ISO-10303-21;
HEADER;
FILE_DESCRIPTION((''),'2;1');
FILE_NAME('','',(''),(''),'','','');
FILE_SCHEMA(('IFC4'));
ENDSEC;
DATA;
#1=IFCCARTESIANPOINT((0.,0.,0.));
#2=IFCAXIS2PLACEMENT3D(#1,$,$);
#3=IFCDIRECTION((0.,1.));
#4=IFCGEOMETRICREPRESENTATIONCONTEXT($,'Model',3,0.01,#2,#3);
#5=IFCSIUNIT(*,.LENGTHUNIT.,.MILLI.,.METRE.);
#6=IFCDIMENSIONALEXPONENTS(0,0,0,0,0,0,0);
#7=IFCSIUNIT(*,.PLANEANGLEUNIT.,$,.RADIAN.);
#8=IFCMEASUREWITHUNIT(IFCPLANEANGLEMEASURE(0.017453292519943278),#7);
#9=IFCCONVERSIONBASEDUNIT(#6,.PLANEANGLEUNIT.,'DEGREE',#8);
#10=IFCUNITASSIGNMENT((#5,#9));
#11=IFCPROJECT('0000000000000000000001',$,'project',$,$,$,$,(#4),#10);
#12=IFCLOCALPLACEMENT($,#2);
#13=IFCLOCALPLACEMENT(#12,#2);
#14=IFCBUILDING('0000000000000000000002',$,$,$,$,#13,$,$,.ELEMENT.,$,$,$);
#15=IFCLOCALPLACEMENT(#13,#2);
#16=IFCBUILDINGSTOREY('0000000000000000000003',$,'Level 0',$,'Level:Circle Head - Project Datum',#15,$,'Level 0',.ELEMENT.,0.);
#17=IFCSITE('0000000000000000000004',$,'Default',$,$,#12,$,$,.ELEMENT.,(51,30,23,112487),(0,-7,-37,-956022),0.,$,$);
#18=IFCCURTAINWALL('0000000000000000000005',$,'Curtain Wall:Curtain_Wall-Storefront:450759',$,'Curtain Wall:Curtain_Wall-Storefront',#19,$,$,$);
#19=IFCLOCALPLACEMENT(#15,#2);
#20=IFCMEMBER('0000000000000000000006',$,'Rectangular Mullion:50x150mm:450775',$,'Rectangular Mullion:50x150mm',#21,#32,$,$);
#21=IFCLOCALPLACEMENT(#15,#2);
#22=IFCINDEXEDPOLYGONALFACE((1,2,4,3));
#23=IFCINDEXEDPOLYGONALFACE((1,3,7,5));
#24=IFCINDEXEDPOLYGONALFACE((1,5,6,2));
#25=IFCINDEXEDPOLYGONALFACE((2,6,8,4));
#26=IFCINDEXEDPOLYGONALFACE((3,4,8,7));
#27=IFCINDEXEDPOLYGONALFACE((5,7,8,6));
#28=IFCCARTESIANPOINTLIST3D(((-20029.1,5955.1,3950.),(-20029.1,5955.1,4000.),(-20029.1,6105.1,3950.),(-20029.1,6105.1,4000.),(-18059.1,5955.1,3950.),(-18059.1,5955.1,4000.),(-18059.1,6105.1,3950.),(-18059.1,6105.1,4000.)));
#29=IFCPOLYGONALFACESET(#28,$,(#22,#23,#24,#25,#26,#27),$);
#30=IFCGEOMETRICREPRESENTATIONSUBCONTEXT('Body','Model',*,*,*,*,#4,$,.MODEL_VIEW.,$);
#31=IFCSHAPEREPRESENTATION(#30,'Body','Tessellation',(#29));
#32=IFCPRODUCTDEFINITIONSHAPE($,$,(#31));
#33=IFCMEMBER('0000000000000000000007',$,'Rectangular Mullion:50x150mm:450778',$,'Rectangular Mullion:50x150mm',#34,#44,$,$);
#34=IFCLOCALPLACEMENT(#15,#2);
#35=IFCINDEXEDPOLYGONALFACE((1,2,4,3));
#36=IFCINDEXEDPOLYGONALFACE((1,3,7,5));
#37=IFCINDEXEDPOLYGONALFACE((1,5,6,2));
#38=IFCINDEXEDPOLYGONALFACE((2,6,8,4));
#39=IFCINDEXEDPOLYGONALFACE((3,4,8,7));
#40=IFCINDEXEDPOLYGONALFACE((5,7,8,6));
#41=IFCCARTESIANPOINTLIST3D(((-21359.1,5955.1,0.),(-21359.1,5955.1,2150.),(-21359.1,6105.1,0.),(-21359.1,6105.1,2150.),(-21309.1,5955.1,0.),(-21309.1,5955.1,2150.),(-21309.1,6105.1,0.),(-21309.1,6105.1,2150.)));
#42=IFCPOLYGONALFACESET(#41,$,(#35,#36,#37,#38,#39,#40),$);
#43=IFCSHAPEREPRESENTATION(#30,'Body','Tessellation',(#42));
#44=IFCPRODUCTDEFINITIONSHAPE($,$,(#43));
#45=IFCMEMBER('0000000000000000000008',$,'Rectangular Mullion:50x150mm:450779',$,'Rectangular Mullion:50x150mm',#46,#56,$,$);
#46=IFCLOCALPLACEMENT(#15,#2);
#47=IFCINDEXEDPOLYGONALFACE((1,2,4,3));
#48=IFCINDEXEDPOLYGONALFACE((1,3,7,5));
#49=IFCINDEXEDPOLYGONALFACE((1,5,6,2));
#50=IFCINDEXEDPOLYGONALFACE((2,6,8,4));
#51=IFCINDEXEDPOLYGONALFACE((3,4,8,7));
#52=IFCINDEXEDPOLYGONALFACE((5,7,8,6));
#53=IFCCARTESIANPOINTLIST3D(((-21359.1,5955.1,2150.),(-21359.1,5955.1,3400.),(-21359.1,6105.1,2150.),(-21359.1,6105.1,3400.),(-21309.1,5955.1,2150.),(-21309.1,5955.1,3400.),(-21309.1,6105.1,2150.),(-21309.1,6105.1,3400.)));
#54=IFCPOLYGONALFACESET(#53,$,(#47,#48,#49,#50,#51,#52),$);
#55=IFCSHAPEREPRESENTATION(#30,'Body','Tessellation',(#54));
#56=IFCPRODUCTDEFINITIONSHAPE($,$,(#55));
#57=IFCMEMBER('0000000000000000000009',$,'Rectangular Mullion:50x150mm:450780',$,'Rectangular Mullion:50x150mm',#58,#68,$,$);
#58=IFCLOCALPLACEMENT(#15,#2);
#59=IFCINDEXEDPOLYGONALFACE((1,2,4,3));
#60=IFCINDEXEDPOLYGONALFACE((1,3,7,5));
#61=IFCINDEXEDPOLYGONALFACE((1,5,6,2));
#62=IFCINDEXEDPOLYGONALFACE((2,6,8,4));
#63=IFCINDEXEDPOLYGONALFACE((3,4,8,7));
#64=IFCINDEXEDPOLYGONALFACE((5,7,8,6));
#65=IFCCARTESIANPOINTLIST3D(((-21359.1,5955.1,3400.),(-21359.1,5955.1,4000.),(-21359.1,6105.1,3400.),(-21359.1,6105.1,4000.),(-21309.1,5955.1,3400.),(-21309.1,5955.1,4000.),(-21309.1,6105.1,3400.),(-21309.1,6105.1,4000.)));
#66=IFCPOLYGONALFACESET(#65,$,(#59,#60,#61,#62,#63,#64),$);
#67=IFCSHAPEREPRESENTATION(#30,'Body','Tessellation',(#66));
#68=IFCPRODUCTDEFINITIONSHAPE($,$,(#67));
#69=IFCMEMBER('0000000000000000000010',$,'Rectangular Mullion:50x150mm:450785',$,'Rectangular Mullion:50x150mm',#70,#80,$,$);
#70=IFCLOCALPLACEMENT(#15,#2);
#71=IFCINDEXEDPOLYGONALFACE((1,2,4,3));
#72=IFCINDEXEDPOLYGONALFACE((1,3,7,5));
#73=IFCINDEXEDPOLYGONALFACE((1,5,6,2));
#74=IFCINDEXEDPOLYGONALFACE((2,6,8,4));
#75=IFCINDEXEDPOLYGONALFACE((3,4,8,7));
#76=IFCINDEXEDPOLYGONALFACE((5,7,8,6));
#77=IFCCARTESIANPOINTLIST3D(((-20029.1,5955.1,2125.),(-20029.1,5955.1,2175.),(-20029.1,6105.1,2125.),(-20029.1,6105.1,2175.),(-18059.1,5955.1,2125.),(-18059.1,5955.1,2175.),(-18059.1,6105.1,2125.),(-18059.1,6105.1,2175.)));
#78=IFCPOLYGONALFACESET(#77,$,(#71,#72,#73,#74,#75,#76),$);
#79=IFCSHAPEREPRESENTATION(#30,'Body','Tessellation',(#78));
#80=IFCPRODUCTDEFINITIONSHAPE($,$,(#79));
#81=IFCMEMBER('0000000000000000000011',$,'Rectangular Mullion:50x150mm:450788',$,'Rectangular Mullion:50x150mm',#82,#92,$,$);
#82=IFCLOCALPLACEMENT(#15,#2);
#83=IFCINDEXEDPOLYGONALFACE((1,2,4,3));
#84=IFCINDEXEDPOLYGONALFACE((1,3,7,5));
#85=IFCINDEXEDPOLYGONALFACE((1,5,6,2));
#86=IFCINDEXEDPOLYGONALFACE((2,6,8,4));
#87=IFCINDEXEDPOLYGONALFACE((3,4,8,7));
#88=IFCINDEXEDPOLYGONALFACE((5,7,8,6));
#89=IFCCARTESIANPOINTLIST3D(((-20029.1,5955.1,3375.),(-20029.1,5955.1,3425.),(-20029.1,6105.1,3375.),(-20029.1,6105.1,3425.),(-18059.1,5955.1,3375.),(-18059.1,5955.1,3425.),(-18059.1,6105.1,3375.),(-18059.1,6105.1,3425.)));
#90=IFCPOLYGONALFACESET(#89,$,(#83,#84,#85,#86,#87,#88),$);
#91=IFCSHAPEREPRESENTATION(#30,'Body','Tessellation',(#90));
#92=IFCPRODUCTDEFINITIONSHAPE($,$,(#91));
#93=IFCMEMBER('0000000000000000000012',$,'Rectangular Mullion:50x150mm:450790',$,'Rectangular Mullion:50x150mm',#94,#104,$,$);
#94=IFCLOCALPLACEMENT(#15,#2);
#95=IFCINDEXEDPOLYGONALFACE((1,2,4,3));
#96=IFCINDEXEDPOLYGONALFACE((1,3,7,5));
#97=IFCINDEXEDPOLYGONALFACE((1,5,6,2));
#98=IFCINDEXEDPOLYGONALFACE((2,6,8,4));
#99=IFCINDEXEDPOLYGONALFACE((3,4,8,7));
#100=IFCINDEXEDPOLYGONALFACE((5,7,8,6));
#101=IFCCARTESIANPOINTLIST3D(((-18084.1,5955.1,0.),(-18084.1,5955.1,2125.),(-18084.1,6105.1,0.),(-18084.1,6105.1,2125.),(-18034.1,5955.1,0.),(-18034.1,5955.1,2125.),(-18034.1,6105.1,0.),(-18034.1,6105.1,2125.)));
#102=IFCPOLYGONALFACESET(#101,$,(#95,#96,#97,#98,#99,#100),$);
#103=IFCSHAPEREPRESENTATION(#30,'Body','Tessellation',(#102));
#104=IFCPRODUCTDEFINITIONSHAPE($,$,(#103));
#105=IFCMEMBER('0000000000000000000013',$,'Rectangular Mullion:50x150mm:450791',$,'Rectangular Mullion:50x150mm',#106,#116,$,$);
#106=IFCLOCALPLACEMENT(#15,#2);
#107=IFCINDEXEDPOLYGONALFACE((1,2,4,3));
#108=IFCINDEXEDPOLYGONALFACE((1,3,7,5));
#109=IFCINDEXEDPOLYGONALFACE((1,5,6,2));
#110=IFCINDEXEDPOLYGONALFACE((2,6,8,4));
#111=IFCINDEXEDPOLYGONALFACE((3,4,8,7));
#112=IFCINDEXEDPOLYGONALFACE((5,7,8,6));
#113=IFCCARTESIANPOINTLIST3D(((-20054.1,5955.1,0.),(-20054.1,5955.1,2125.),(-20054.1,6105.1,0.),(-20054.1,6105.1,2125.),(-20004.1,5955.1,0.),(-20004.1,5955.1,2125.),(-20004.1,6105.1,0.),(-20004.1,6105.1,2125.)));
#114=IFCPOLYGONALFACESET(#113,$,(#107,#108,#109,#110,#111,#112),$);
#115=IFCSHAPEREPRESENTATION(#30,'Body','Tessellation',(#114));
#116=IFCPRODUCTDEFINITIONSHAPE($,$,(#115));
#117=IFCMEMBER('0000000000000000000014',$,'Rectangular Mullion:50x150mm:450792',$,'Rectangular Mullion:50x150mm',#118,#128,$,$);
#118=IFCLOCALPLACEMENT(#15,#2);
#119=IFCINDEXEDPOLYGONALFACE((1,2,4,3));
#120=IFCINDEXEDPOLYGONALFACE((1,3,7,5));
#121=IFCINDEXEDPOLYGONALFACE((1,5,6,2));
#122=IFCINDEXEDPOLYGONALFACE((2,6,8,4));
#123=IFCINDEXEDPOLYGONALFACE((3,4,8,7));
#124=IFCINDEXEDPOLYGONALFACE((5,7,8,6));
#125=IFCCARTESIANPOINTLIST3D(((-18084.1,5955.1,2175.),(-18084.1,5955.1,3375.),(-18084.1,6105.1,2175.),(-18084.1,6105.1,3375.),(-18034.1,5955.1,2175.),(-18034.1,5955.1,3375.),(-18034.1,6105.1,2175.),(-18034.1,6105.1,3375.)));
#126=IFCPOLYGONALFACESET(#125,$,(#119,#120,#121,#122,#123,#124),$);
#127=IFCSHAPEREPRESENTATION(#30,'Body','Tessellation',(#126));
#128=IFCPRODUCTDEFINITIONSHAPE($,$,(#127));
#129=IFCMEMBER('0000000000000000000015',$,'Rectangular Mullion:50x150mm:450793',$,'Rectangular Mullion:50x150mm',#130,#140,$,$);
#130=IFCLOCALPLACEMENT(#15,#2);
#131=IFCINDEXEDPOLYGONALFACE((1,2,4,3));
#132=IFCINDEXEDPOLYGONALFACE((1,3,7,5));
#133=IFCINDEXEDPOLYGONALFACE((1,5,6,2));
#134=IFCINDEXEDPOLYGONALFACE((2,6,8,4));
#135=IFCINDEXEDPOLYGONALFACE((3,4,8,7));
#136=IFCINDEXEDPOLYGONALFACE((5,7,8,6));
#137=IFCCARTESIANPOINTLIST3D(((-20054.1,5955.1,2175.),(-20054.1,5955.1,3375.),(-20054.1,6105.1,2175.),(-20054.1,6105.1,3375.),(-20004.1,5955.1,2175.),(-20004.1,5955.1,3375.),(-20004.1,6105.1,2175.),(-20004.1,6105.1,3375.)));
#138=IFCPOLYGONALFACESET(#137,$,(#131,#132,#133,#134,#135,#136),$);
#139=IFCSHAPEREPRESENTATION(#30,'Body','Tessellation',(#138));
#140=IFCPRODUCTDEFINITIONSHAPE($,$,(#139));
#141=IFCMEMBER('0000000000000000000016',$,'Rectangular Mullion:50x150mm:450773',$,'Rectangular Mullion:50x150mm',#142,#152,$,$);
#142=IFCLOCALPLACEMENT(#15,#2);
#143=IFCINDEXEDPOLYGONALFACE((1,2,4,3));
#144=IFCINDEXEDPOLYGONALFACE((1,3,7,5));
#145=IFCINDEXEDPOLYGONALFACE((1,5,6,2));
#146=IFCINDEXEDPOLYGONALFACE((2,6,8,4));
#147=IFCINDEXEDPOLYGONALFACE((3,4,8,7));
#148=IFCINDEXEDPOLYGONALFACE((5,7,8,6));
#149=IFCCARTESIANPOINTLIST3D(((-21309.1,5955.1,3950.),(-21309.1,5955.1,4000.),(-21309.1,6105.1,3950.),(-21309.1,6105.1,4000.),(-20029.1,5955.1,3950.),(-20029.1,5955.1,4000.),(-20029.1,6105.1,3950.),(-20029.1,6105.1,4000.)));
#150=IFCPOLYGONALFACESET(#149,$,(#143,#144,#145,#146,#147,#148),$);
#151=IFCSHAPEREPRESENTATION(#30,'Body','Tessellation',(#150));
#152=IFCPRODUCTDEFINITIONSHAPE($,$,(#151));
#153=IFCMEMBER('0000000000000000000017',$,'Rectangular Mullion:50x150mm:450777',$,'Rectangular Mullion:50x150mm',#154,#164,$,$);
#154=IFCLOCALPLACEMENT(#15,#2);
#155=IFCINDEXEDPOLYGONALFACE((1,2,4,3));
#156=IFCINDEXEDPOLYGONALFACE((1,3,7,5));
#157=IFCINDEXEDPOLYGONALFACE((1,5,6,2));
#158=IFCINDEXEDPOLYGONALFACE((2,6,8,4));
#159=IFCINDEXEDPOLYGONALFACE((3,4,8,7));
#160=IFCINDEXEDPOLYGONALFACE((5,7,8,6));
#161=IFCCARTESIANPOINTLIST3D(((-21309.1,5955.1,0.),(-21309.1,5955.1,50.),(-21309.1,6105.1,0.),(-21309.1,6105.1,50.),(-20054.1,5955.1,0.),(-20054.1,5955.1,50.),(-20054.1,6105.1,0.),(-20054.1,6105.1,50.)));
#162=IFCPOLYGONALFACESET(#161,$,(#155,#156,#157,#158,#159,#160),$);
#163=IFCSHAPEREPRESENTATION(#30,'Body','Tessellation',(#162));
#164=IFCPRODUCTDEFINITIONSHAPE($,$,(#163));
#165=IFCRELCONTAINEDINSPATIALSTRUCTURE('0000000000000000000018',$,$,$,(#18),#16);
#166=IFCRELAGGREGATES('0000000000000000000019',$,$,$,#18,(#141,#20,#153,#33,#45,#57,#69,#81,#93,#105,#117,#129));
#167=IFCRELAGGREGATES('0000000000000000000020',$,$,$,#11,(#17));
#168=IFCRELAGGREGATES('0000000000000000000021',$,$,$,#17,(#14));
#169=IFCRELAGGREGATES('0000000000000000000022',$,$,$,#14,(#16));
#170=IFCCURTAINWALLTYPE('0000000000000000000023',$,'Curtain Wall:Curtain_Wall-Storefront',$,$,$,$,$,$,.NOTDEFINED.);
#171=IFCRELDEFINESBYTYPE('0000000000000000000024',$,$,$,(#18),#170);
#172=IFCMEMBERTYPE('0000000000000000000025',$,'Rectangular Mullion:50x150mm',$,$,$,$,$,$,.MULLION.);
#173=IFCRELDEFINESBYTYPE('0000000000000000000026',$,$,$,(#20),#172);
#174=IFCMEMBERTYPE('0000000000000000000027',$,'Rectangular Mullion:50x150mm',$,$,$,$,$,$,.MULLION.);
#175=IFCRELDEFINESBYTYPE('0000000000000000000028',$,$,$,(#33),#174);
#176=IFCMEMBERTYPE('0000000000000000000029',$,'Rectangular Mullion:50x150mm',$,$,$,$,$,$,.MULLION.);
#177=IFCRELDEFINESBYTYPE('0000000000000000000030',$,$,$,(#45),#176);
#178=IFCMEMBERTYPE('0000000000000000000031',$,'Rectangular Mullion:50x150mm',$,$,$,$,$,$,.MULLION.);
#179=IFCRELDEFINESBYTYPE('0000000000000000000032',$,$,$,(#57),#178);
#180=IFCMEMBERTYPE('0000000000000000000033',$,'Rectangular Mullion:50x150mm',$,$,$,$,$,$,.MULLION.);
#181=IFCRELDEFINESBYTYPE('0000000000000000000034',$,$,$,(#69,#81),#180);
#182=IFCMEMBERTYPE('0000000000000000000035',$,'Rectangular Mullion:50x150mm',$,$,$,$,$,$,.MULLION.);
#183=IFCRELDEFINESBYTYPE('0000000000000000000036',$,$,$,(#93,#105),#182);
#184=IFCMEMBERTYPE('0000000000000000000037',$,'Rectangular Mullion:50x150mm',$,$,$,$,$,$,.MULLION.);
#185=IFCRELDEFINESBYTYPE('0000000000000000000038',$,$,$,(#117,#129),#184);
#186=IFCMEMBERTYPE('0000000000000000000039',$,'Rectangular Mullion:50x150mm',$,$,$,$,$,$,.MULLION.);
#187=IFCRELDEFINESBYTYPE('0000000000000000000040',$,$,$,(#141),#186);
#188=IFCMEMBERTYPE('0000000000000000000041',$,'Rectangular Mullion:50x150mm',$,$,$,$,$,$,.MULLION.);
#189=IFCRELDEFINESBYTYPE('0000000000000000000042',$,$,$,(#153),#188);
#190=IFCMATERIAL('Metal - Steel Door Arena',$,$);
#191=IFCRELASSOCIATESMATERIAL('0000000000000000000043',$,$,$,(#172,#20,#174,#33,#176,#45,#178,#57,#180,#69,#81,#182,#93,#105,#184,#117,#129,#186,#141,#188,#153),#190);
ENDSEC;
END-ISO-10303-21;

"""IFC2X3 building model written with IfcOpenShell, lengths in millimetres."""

from ifc_helpers import new_model, entity, si_unit, converted_unit, direction, frame, origin, origin_2d_with_axis, place, context, subcontext, project, spatial, rectangle, extrude, source, transform, mapped, material, type_object, type_shapes, element, aggregate, save


model = new_model("IFC2X3")

# Units and contexts
model_context = context("Model", 3, precision=0.01, world=origin(), true_north=direction((0.0, 1.0)))
body_context = subcontext(model_context, "Body", "Model", "MODEL_VIEW")
ifc_project = project(units=[si_unit("LENGTHUNIT", "METRE", prefix="MILLI"), converted_unit("PLANEANGLEUNIT", "DEGREE", entity("IfcPlaneAngleMeasure", 0.017453292519943278), si_unit("PLANEANGLEUNIT", "RADIAN"), dimensions=[0, 0, 0, 0, 0, 0, 0])], contexts=[model_context])

# Site, building, storey
site_placement = place(None, origin())
site = spatial("IfcSite", under=ifc_project, at=site_placement, Name="Default", CompositionType="ELEMENT", RefLatitude=(51, 30, 23, 112487), RefLongitude=(0, -7, -37, -956022), RefElevation=0.0)
building_placement = place(site_placement, origin())
building = spatial("IfcBuilding", under=site, at=building_placement, CompositionType="ELEMENT")
storey_placement = place(building_placement, origin())
storey = spatial("IfcBuildingStorey", under=building, at=storey_placement, Name="Level 0", ObjectType="Level:Circle Head - Project Datum", LongName="Level 0", CompositionType="ELEMENT", Elevation=0.0)

# Curtain wall, members
curtain_wall_type = type_object("IfcCurtainWallType", Name="Curtain Wall:Curtain_Wall-Storefront", PredefinedType="NOTDEFINED")
curtain_wall_placement = place(storey_placement, origin())
curtain_wall = element("IfcCurtainWall", 1, at=curtain_wall_placement, inside=storey, type_object=curtain_wall_type, Name="Curtain Wall:Curtain_Wall-Storefront:450759", ObjectType="Curtain Wall:Curtain_Wall-Storefront")
ifc_material_1 = material(Name="Metal - Steel Door Arena")
member_type_1 = type_object("IfcMemberType", Name="Rectangular Mullion:50x150mm", PredefinedType="MULLION", material=ifc_material_1)
shared_shape_1 = source(origin(), body_context, "Body", "SweptSolid", [
    extrude(rectangle(XDim=50.0, YDim=150.0, at=origin_2d_with_axis()), frame((-25.0, 0.0, -1970.0), z_axis=(0.0, 0.0, 1.0), x_axis=(-1.0, 0.0, 0.0)), (0.0, 0.0, 1.0), 1970.0),
])
type_shapes(member_type_1, [shared_shape_1])
member_1_placement = place(curtain_wall_placement, frame((-20029.1, 6030.1, 4000.0), z_axis=(-1.0, 0.0, 0.0), x_axis=(0.0, 0.0, 1.0)))
member_1 = element("IfcMember", 2, at=member_1_placement, type_object=member_type_1, material=ifc_material_1, Name="Rectangular Mullion:50x150mm:450775", ObjectType="Rectangular Mullion:50x150mm", context=body_context, shape_type="MappedRepresentation", body=[
    mapped(shared_shape_1, transform((0.0, 0.0, 0.0), scale=1.0)),
])
member_type_2 = type_object("IfcMemberType", Name="Rectangular Mullion:50x150mm", PredefinedType="MULLION", material=ifc_material_1)
shared_shape_2 = source(origin(), body_context, "Body", "SweptSolid", [
    extrude(rectangle(XDim=50.0, YDim=150.0, at=origin_2d_with_axis()), frame((-25.0, 0.0, -2150.0), z_axis=(0.0, 0.0, 1.0), x_axis=(-1.0, 0.0, 0.0)), (0.0, 0.0, 1.0), 2150.0),
])
type_shapes(member_type_2, [shared_shape_2])
member_2_placement = place(curtain_wall_placement, frame((-21359.1, 6030.1, 0.0), z_axis=(0.0, 0.0, -1.0), x_axis=(-1.0, 0.0, 0.0)))
member_2 = element("IfcMember", 3, at=member_2_placement, type_object=member_type_2, material=ifc_material_1, Name="Rectangular Mullion:50x150mm:450778", ObjectType="Rectangular Mullion:50x150mm", context=body_context, shape_type="MappedRepresentation", body=[
    mapped(shared_shape_2, transform((0.0, 0.0, 0.0), scale=1.0)),
])
member_type_3 = type_object("IfcMemberType", Name="Rectangular Mullion:50x150mm", PredefinedType="MULLION", material=ifc_material_1)
shared_shape_3 = source(origin(), body_context, "Body", "SweptSolid", [
    extrude(rectangle(XDim=50.0, YDim=150.0, at=origin_2d_with_axis()), frame((-25.0, 0.0, -1250.0), z_axis=(0.0, 0.0, 1.0), x_axis=(-1.0, 0.0, 0.0)), (0.0, 0.0, 1.0), 1250.0),
])
type_shapes(member_type_3, [shared_shape_3])
member_3_placement = place(curtain_wall_placement, frame((-21359.1, 6030.1, 2150.0), z_axis=(0.0, 0.0, -1.0), x_axis=(-1.0, 0.0, 0.0)))
member_3 = element("IfcMember", 4, at=member_3_placement, type_object=member_type_3, material=ifc_material_1, Name="Rectangular Mullion:50x150mm:450779", ObjectType="Rectangular Mullion:50x150mm", context=body_context, shape_type="MappedRepresentation", body=[
    mapped(shared_shape_3, transform((0.0, 0.0, 0.0), scale=1.0)),
])
member_type_4 = type_object("IfcMemberType", Name="Rectangular Mullion:50x150mm", PredefinedType="MULLION", material=ifc_material_1)
shared_shape_4 = source(origin(), body_context, "Body", "SweptSolid", [
    extrude(rectangle(XDim=50.0, YDim=150.0, at=origin_2d_with_axis()), frame((-25.0, 0.0, -600.0), z_axis=(0.0, 0.0, 1.0), x_axis=(-1.0, 0.0, 0.0)), (0.0, 0.0, 1.0), 600.0),
])
type_shapes(member_type_4, [shared_shape_4])
member_4_placement = place(curtain_wall_placement, frame((-21359.1, 6030.1, 3400.0), z_axis=(0.0, 0.0, -1.0), x_axis=(-1.0, 0.0, 0.0)))
member_4 = element("IfcMember", 5, at=member_4_placement, type_object=member_type_4, material=ifc_material_1, Name="Rectangular Mullion:50x150mm:450780", ObjectType="Rectangular Mullion:50x150mm", context=body_context, shape_type="MappedRepresentation", body=[
    mapped(shared_shape_4, transform((0.0, 0.0, 0.0), scale=1.0)),
])
member_type_5 = type_object("IfcMemberType", Name="Rectangular Mullion:50x150mm", PredefinedType="MULLION", material=ifc_material_1)
shared_shape_5 = source(origin(), body_context, "Body", "SweptSolid", [
    extrude(rectangle(XDim=50.0, YDim=150.0, at=origin_2d_with_axis()), frame((0.0, 0.0, -1970.0), z_axis=(0.0, 0.0, 1.0), x_axis=(-1.0, 0.0, 0.0)), (0.0, 0.0, 1.0), 1970.0),
])
type_shapes(member_type_5, [shared_shape_5])
member_5_placement = place(curtain_wall_placement, frame((-20029.1, 6030.1, 2150.0), z_axis=(-1.0, 0.0, 0.0), x_axis=(0.0, 0.0, 1.0)))
member_5 = element("IfcMember", 6, at=member_5_placement, type_object=member_type_5, material=ifc_material_1, Name="Rectangular Mullion:50x150mm:450785", ObjectType="Rectangular Mullion:50x150mm", context=body_context, shape_type="MappedRepresentation", body=[
    mapped(shared_shape_5, transform((0.0, 0.0, 0.0), scale=1.0)),
])
member_6_placement = place(curtain_wall_placement, frame((-20029.1, 6030.1, 3400.0), z_axis=(-1.0, 0.0, 0.0), x_axis=(0.0, 0.0, 1.0)))
member_6 = element("IfcMember", 7, at=member_6_placement, type_object=member_type_5, material=ifc_material_1, Name="Rectangular Mullion:50x150mm:450788", ObjectType="Rectangular Mullion:50x150mm", context=body_context, shape_type="MappedRepresentation", body=[
    mapped(shared_shape_5, transform((0.0, 0.0, 0.0), scale=1.0)),
])
member_type_6 = type_object("IfcMemberType", Name="Rectangular Mullion:50x150mm", PredefinedType="MULLION", material=ifc_material_1)
shared_shape_6 = source(origin(), body_context, "Body", "SweptSolid", [
    extrude(rectangle(XDim=50.0, YDim=150.0, at=origin_2d_with_axis()), frame((0.0, 0.0, -2125.0), z_axis=(0.0, 0.0, 1.0), x_axis=(-1.0, 0.0, 0.0)), (0.0, 0.0, 1.0), 2125.0),
])
type_shapes(member_type_6, [shared_shape_6])
member_7_placement = place(curtain_wall_placement, frame((-18059.1, 6030.1, 0.0), z_axis=(0.0, 0.0, -1.0), x_axis=(-1.0, 0.0, 0.0)))
member_7 = element("IfcMember", 8, at=member_7_placement, type_object=member_type_6, material=ifc_material_1, Name="Rectangular Mullion:50x150mm:450790", ObjectType="Rectangular Mullion:50x150mm", context=body_context, shape_type="MappedRepresentation", body=[
    mapped(shared_shape_6, transform((0.0, 0.0, 0.0), scale=1.0)),
])
member_8_placement = place(curtain_wall_placement, frame((-20029.1, 6030.1, 0.0), z_axis=(0.0, 0.0, -1.0), x_axis=(-1.0, 0.0, 0.0)))
member_8 = element("IfcMember", 9, at=member_8_placement, type_object=member_type_6, material=ifc_material_1, Name="Rectangular Mullion:50x150mm:450791", ObjectType="Rectangular Mullion:50x150mm", context=body_context, shape_type="MappedRepresentation", body=[
    mapped(shared_shape_6, transform((0.0, 0.0, 0.0), scale=1.0)),
])
member_type_7 = type_object("IfcMemberType", Name="Rectangular Mullion:50x150mm", PredefinedType="MULLION", material=ifc_material_1)
shared_shape_7 = source(origin(), body_context, "Body", "SweptSolid", [
    extrude(rectangle(XDim=50.0, YDim=150.0, at=origin_2d_with_axis()), frame((0.0, 0.0, -1200.0), z_axis=(0.0, 0.0, 1.0), x_axis=(-1.0, 0.0, 0.0)), (0.0, 0.0, 1.0), 1200.0),
])
type_shapes(member_type_7, [shared_shape_7])
member_9_placement = place(curtain_wall_placement, frame((-18059.1, 6030.1, 2175.0), z_axis=(0.0, 0.0, -1.0), x_axis=(-1.0, 0.0, 0.0)))
member_9 = element("IfcMember", 10, at=member_9_placement, type_object=member_type_7, material=ifc_material_1, Name="Rectangular Mullion:50x150mm:450792", ObjectType="Rectangular Mullion:50x150mm", context=body_context, shape_type="MappedRepresentation", body=[
    mapped(shared_shape_7, transform((0.0, 0.0, 0.0), scale=1.0)),
])
member_10_placement = place(curtain_wall_placement, frame((-20029.1, 6030.1, 2175.0), z_axis=(0.0, 0.0, -1.0), x_axis=(-1.0, 0.0, 0.0)))
member_10 = element("IfcMember", 11, at=member_10_placement, type_object=member_type_7, material=ifc_material_1, Name="Rectangular Mullion:50x150mm:450793", ObjectType="Rectangular Mullion:50x150mm", context=body_context, shape_type="MappedRepresentation", body=[
    mapped(shared_shape_7, transform((0.0, 0.0, 0.0), scale=1.0)),
])
member_type_8 = type_object("IfcMemberType", Name="Rectangular Mullion:50x150mm", PredefinedType="MULLION", material=ifc_material_1)
shared_shape_8 = source(origin(), body_context, "Body", "SweptSolid", [
    extrude(rectangle(XDim=50.0, YDim=150.0, at=origin_2d_with_axis()), frame((-25.0, 0.0, -1280.0), z_axis=(0.0, 0.0, 1.0), x_axis=(-1.0, 0.0, 0.0)), (0.0, 0.0, 1.0), 1280.0),
])
type_shapes(member_type_8, [shared_shape_8])
member_11_placement = place(curtain_wall_placement, frame((-21309.1, 6030.1, 4000.0), z_axis=(-1.0, 0.0, 0.0), x_axis=(0.0, 0.0, 1.0)))
member_11 = element("IfcMember", 12, at=member_11_placement, type_object=member_type_8, material=ifc_material_1, Name="Rectangular Mullion:50x150mm:450773", ObjectType="Rectangular Mullion:50x150mm", context=body_context, shape_type="MappedRepresentation", body=[
    mapped(shared_shape_8, transform((0.0, 0.0, 0.0), scale=1.0)),
])
member_type_9 = type_object("IfcMemberType", Name="Rectangular Mullion:50x150mm", PredefinedType="MULLION", material=ifc_material_1)
shared_shape_9 = source(origin(), body_context, "Body", "SweptSolid", [
    extrude(rectangle(XDim=50.0, YDim=150.0, at=origin_2d_with_axis()), frame((-25.0, 0.0, -1255.0), z_axis=(0.0, 0.0, 1.0), x_axis=(-1.0, 0.0, 0.0)), (0.0, 0.0, 1.0), 1255.0),
])
type_shapes(member_type_9, [shared_shape_9])
member_12_placement = place(curtain_wall_placement, frame((-20054.1, 6030.1, 0.0), z_axis=(1.0, 0.0, 0.0), x_axis=(0.0, 0.0, -1.0)))
member_12 = element("IfcMember", 13, at=member_12_placement, type_object=member_type_9, material=ifc_material_1, Name="Rectangular Mullion:50x150mm:450777", ObjectType="Rectangular Mullion:50x150mm", context=body_context, shape_type="MappedRepresentation", body=[
    mapped(shared_shape_9, transform((0.0, 0.0, 0.0), scale=1.0)),
])
aggregate(curtain_wall, [member_11, member_1, member_12, member_2, member_3, member_4, member_5, member_6, member_7, member_8, member_9, member_10])

save(model, "model.ifc")
